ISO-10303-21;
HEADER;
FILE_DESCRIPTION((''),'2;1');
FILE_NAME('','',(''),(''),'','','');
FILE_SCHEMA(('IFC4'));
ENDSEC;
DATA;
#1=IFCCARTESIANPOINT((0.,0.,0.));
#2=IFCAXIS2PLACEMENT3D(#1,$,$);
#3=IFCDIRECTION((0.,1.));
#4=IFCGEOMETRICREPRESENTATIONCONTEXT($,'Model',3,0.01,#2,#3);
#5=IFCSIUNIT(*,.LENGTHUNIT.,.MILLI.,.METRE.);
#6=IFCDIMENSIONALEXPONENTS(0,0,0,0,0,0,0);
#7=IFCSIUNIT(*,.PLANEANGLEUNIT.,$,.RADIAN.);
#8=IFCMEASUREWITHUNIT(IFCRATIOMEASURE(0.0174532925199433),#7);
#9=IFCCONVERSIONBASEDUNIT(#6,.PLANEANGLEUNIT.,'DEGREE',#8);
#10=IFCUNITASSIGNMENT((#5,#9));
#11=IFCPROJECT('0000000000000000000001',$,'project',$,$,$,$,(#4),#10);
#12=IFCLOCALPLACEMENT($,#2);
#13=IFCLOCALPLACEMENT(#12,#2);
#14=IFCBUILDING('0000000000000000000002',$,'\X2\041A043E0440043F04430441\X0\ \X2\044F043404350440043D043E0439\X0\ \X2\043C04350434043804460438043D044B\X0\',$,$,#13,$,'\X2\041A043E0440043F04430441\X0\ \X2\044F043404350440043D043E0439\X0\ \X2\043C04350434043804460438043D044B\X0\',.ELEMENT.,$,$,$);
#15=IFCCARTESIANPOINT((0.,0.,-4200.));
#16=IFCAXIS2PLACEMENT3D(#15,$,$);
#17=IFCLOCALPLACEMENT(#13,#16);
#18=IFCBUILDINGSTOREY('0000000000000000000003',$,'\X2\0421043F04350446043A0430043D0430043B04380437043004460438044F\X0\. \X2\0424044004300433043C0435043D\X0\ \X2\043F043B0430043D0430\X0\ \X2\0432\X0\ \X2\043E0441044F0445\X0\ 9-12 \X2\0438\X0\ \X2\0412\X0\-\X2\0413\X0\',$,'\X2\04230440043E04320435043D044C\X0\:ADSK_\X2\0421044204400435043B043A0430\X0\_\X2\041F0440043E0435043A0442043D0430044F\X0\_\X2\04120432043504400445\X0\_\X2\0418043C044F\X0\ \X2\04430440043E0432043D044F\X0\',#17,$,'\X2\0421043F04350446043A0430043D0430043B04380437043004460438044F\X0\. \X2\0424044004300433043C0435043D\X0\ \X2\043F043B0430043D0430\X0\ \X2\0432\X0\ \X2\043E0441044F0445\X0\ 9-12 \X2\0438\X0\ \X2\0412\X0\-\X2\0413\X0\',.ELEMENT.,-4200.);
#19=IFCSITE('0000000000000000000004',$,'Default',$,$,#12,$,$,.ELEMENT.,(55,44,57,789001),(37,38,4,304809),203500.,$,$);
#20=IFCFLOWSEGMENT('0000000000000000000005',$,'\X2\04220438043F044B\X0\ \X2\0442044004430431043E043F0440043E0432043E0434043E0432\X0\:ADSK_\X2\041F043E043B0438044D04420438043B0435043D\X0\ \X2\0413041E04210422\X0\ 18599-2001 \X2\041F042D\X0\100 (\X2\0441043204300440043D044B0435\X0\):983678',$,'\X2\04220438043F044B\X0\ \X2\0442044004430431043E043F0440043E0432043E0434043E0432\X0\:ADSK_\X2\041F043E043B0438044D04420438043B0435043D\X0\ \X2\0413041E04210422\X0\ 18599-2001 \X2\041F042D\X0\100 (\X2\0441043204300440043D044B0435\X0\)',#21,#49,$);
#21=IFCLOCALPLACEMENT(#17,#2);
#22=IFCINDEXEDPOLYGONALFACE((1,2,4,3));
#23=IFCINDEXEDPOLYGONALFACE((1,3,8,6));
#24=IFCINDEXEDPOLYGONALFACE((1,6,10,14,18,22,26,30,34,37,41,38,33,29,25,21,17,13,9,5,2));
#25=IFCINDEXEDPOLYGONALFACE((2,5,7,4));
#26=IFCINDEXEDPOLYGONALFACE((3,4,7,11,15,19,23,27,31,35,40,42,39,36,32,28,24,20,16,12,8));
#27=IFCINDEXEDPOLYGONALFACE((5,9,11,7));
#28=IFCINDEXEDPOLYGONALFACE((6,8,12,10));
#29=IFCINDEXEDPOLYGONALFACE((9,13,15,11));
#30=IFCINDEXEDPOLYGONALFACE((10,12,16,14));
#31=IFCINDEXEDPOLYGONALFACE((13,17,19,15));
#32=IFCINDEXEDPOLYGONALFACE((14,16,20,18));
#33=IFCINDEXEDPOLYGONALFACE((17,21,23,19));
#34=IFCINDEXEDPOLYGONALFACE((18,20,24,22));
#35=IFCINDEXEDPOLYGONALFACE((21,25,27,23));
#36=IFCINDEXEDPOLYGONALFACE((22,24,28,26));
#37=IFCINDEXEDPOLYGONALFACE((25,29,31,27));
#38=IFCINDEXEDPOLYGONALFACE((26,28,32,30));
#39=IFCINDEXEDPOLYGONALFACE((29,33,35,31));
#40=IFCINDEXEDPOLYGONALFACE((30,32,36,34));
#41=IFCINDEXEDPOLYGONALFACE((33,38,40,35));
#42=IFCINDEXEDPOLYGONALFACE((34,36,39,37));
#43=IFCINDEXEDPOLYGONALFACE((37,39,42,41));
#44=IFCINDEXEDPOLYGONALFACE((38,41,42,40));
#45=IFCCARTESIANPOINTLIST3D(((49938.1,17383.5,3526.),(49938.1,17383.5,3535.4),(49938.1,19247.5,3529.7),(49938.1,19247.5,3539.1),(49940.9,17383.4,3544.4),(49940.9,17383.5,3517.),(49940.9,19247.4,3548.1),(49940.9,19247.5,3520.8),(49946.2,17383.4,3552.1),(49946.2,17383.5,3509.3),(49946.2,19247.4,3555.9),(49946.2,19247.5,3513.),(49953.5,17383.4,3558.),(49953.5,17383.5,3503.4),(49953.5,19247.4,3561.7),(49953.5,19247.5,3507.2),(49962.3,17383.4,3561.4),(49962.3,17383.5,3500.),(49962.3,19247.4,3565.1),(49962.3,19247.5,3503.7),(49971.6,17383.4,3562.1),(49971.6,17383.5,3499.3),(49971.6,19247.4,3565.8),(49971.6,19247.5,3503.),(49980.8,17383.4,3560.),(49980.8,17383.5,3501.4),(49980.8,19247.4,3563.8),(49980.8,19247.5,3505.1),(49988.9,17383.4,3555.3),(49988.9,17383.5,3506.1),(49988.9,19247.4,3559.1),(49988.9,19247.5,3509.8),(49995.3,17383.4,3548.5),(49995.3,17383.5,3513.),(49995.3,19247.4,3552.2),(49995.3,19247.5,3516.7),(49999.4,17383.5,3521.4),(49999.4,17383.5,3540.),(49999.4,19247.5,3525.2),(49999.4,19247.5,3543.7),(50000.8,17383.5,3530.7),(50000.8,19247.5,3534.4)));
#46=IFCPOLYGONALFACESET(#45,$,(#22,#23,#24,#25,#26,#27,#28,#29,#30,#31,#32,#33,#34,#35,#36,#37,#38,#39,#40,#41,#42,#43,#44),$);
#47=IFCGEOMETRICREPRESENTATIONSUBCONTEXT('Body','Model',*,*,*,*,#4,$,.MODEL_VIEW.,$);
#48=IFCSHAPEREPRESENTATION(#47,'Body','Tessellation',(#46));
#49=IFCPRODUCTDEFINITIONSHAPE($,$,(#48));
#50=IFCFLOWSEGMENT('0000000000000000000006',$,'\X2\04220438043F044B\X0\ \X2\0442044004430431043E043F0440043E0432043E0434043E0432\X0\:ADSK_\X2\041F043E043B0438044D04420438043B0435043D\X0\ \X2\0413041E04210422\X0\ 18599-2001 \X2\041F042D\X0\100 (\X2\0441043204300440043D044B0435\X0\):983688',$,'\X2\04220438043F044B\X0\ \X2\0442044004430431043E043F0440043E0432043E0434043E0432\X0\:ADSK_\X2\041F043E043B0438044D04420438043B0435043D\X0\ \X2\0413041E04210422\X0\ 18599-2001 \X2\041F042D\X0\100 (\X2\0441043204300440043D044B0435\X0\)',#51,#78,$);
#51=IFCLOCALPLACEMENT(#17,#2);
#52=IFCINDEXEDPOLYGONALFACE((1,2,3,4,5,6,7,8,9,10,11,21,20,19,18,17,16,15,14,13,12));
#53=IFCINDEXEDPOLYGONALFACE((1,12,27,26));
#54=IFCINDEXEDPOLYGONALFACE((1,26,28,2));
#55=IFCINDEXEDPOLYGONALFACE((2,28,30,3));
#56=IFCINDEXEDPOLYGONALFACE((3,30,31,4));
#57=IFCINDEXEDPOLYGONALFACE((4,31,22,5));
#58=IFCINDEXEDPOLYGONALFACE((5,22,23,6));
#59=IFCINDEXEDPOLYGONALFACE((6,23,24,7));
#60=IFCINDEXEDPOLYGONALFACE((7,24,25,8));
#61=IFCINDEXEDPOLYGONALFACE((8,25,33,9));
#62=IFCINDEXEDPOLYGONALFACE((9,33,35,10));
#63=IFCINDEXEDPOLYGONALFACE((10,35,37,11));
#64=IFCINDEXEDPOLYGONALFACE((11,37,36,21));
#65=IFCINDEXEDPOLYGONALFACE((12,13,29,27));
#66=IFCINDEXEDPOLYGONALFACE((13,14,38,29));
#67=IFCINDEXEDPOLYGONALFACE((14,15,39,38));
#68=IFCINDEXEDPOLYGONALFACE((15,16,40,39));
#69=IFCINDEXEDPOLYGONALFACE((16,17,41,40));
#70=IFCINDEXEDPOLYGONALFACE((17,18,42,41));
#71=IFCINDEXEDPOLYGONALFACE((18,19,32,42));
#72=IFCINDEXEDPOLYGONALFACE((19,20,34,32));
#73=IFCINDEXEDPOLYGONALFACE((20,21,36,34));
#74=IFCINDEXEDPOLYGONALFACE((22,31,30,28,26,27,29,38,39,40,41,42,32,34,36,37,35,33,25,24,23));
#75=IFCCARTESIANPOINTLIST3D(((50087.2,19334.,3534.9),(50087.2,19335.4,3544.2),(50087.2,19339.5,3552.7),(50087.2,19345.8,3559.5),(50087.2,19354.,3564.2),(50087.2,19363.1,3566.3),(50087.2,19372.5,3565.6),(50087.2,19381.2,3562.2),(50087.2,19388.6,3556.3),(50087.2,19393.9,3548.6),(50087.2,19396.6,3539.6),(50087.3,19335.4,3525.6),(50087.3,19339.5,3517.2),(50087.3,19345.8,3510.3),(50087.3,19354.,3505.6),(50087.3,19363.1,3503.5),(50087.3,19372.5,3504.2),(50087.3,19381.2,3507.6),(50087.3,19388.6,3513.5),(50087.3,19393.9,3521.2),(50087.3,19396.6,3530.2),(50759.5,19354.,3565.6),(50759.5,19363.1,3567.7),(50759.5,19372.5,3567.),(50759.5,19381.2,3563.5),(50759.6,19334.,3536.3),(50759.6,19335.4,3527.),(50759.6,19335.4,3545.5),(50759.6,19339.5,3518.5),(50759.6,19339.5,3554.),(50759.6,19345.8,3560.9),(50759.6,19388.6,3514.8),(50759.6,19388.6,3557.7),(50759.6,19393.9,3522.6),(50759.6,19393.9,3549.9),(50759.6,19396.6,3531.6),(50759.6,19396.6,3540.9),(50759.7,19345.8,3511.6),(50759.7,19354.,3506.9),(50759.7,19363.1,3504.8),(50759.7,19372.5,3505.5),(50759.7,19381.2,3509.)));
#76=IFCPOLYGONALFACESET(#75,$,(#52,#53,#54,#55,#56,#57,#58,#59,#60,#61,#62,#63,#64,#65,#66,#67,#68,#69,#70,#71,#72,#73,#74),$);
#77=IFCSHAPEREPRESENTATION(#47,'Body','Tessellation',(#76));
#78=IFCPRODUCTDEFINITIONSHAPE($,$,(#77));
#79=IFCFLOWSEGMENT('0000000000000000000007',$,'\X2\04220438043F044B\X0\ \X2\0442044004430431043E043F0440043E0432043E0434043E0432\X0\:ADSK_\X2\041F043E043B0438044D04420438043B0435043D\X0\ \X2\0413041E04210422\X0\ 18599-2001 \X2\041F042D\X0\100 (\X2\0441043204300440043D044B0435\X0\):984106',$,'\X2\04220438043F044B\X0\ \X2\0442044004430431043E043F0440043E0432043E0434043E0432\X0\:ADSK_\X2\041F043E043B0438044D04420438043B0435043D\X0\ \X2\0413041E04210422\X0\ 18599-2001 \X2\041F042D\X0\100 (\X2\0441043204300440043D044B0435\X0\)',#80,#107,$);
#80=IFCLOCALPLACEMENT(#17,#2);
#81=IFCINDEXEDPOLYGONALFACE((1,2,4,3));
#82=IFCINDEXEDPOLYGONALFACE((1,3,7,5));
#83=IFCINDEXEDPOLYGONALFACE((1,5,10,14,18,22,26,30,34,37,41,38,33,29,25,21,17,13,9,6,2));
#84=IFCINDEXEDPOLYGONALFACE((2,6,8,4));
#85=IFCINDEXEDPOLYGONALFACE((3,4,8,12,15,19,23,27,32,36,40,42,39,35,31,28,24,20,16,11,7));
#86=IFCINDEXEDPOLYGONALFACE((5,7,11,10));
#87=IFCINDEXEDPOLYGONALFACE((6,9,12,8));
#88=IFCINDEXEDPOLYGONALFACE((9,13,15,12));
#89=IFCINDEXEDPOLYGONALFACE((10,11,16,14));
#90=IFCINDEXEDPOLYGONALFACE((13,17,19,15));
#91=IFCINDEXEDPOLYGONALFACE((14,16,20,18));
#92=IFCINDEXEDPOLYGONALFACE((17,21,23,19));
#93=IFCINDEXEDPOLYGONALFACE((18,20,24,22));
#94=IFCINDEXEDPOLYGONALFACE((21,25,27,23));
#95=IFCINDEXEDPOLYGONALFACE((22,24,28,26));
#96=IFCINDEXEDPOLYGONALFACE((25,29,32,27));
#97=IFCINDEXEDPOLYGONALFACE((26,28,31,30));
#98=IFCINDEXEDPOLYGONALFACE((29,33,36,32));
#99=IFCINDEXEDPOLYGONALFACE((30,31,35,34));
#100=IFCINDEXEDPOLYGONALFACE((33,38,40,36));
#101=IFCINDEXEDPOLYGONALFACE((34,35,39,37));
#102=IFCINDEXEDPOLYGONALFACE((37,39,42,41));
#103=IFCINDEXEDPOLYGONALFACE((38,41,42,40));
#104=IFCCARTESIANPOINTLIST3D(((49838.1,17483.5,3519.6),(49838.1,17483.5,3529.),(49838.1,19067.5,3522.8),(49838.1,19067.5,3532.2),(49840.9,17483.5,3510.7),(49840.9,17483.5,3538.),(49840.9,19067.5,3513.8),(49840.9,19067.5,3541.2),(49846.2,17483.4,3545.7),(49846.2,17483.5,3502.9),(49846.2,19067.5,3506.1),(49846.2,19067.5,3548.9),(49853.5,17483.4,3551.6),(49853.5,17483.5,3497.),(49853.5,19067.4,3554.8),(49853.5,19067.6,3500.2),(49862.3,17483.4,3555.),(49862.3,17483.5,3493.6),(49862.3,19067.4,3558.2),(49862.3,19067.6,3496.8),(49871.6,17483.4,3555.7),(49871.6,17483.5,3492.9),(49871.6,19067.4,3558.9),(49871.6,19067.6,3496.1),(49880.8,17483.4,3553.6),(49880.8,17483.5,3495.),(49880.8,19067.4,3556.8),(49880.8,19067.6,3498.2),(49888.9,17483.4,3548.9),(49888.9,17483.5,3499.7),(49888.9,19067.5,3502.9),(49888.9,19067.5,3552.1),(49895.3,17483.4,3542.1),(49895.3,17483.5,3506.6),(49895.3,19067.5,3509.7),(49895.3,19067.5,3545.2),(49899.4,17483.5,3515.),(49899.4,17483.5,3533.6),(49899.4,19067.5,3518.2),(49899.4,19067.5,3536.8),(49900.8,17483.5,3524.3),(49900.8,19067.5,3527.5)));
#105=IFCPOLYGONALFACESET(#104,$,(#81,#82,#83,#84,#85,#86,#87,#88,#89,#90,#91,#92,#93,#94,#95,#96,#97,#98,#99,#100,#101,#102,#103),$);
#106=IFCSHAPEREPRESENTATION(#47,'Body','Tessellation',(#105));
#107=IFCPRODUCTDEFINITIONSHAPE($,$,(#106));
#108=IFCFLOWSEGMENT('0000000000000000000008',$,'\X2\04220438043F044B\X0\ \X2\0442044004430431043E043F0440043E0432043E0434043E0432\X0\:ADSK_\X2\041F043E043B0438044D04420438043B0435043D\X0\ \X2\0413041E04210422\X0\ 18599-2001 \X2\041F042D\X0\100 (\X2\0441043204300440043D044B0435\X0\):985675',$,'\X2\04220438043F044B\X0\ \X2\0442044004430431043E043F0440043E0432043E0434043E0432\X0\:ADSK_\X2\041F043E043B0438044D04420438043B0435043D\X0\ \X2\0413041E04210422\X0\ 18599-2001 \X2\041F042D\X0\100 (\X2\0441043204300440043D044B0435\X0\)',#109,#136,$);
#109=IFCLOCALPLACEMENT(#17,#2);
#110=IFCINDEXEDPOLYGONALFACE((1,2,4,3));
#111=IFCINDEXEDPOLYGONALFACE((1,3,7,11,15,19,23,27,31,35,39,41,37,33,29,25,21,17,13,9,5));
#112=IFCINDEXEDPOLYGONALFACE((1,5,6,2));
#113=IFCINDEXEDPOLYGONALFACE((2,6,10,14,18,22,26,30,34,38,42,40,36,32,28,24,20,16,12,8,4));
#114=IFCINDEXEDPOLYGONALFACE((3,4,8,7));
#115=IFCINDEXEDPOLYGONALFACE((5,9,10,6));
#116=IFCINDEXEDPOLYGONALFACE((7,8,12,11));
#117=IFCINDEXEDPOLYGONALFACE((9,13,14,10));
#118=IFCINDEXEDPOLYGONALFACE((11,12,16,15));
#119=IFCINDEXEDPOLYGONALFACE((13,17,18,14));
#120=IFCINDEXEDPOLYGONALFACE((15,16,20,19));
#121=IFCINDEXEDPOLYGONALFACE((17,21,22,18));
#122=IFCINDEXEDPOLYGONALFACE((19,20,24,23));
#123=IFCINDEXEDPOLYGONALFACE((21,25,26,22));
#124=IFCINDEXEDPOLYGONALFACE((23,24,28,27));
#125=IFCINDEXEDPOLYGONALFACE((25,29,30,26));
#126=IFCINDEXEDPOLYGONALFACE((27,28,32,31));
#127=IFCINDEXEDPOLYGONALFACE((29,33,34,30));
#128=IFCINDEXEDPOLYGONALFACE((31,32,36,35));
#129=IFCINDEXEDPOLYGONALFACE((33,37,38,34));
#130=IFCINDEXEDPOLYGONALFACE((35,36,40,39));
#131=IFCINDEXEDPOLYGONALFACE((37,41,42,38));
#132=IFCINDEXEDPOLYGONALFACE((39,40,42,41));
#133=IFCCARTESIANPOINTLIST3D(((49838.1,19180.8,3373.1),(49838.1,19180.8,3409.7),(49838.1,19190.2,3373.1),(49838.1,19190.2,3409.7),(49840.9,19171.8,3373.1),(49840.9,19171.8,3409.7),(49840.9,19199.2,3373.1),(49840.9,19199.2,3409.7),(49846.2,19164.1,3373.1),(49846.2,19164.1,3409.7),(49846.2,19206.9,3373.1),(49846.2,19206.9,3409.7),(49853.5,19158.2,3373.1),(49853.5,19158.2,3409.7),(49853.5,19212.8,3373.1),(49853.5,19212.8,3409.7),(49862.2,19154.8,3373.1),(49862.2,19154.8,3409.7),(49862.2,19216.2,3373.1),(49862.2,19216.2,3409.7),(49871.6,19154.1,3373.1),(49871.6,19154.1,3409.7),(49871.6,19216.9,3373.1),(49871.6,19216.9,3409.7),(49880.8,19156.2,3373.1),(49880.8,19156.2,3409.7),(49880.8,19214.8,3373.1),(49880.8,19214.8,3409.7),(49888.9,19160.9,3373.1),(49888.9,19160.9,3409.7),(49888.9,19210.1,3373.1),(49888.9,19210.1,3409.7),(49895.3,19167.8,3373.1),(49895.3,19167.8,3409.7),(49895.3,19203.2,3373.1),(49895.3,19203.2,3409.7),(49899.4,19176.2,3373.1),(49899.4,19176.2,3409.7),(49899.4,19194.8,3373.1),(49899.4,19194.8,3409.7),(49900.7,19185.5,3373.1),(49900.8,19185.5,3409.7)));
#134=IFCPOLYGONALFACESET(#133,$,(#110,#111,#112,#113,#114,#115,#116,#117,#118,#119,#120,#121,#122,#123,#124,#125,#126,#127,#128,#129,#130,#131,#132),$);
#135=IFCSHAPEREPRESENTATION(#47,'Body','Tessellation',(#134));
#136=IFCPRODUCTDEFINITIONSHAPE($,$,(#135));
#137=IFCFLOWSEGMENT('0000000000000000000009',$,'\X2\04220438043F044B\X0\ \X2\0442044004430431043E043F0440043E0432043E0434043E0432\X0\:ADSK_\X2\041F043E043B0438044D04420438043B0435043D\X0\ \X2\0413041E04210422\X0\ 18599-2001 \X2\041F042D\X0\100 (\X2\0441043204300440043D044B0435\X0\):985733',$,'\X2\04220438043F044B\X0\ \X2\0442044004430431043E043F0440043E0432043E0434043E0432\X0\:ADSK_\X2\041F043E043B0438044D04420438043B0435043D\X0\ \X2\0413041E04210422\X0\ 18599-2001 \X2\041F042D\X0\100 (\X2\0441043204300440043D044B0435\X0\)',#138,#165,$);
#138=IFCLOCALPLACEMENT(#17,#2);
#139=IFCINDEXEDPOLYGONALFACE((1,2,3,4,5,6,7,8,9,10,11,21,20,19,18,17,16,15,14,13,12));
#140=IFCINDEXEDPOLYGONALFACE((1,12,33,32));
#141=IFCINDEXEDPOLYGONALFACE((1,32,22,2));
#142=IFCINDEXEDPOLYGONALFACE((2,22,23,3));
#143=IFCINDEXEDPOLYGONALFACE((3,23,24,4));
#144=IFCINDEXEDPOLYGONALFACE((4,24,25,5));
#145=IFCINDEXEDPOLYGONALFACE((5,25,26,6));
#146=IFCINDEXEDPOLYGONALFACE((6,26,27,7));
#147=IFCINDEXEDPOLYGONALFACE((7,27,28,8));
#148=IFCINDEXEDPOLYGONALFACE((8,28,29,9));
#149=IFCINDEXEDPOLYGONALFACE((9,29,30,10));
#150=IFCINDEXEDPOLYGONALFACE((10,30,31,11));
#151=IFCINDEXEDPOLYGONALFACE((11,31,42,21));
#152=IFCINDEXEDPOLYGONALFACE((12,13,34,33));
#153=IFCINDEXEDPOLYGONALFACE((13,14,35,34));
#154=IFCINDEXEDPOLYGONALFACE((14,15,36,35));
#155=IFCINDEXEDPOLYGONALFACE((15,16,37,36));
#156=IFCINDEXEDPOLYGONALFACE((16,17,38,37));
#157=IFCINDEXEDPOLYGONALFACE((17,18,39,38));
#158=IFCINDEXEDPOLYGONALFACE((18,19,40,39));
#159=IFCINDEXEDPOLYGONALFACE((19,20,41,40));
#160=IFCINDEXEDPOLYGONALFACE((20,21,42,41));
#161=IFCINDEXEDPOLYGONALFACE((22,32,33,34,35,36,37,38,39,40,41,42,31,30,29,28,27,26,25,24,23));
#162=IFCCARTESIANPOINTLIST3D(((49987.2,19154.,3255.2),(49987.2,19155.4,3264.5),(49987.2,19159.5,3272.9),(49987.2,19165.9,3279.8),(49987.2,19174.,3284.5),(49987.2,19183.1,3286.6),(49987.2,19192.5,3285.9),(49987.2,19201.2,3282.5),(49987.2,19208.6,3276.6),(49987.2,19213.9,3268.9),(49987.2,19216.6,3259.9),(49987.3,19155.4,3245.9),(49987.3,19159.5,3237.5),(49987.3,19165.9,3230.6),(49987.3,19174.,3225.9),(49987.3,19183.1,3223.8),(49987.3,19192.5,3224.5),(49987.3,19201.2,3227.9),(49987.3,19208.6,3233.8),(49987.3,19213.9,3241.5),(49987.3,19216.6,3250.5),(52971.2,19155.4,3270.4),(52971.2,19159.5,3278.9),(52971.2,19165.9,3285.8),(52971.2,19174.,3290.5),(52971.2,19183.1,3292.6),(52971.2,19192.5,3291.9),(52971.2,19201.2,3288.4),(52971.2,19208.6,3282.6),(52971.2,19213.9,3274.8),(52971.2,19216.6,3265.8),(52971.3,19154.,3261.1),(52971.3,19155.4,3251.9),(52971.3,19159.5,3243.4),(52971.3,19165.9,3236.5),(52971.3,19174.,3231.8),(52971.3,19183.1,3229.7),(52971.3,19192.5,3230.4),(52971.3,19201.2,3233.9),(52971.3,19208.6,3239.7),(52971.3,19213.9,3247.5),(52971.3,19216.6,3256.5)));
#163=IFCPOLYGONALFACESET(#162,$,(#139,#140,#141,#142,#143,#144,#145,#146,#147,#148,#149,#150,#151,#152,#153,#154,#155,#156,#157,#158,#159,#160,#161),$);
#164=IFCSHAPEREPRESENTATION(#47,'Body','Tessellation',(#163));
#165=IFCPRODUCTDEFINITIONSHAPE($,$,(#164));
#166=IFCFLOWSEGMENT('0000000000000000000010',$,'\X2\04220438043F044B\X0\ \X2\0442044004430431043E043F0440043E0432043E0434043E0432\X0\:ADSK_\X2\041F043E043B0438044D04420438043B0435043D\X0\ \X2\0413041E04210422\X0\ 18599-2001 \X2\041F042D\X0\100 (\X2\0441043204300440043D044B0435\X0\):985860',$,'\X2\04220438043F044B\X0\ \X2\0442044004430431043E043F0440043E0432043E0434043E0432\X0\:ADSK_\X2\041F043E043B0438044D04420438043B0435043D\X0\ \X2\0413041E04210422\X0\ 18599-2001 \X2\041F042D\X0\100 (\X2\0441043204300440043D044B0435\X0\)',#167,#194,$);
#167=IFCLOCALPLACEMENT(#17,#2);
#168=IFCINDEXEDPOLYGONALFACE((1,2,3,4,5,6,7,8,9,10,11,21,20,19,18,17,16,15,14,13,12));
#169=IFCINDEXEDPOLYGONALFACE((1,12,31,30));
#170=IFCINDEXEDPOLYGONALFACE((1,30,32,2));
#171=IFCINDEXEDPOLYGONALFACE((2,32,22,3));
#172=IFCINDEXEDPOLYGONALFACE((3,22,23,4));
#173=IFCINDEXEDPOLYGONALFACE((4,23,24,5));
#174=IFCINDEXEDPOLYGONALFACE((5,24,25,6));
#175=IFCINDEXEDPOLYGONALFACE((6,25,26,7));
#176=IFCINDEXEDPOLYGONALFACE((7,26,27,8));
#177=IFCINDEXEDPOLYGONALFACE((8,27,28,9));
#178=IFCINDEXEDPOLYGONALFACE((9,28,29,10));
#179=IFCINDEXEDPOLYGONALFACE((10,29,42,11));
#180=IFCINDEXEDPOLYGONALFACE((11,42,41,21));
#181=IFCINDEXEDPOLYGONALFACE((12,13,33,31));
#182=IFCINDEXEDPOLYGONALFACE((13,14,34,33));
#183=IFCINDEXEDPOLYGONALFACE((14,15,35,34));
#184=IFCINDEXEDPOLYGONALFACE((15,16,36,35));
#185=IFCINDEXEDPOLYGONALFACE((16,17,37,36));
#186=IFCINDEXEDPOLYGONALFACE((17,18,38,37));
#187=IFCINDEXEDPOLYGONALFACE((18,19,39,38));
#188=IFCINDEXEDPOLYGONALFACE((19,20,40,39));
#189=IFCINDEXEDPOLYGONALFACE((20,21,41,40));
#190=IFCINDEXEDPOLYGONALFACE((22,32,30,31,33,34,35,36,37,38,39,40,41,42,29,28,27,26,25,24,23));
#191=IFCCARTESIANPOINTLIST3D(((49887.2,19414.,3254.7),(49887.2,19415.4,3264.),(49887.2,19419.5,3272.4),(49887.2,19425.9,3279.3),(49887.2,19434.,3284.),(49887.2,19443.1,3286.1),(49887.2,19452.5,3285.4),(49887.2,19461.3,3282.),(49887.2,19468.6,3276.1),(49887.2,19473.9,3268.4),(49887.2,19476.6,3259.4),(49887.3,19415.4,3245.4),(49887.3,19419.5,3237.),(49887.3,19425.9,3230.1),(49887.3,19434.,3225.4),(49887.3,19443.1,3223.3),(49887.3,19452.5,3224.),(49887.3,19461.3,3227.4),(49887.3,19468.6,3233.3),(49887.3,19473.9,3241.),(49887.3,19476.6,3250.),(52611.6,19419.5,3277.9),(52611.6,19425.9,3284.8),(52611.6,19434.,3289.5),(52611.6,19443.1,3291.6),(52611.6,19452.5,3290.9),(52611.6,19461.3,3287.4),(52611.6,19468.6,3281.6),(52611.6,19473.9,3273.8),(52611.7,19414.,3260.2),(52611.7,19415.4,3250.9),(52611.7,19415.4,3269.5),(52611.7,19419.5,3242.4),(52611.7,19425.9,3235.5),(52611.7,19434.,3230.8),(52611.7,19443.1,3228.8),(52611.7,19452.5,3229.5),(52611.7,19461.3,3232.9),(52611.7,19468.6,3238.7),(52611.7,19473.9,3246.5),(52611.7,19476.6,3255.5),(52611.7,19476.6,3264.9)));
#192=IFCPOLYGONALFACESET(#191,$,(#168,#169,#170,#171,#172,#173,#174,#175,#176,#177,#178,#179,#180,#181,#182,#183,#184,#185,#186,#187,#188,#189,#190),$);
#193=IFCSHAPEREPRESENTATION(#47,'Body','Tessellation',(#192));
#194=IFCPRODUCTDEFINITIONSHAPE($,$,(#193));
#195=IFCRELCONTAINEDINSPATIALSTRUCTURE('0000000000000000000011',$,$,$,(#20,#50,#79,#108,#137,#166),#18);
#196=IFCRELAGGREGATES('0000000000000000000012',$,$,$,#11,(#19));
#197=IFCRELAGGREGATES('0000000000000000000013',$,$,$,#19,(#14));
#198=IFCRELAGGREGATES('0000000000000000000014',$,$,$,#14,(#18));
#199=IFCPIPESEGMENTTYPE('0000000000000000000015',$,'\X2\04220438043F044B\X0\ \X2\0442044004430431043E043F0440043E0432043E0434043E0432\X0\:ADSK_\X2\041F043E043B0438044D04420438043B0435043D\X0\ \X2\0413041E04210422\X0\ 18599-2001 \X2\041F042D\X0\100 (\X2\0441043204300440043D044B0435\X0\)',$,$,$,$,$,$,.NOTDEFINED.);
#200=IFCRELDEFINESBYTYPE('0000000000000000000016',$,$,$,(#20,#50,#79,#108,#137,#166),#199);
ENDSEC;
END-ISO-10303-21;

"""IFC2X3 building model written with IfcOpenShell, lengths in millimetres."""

from ifc_helpers import new_model, entity, si_unit, converted_unit, direction, frame, origin, origin_2d_with_axis, place, context, subcontext, project, spatial, circle, extrude, type_object, element, save


model = new_model("IFC2X3")

# Units and contexts
model_context = context("Model", 3, precision=0.01, world=origin(), true_north=direction((0.0, 1.0)))
body_context = subcontext(model_context, "Body", "Model", "MODEL_VIEW")
ifc_project = project(units=[si_unit("LENGTHUNIT", "METRE", prefix="MILLI"), converted_unit("PLANEANGLEUNIT", "DEGREE", entity("IfcRatioMeasure", 0.0174532925199433), si_unit("PLANEANGLEUNIT", "RADIAN"), dimensions=[0, 0, 0, 0, 0, 0, 0])], contexts=[model_context])

# Site, building, storey
site_placement = place(None, origin())
site = spatial("IfcSite", under=ifc_project, at=site_placement, Name="Default", CompositionType="ELEMENT", RefLatitude=(55, 44, 57, 789001), RefLongitude=(37, 38, 4, 304809), RefElevation=203500.0)
building_placement = place(site_placement, origin())
building = spatial("IfcBuilding", under=site, at=building_placement, Name="Корпус ядерной медицины", LongName="Корпус ядерной медицины", CompositionType="ELEMENT")
storey_placement = place(building_placement, frame((0.0, 0.0, -4200.0)))
storey = spatial("IfcBuildingStorey", under=building, at=storey_placement, Name="Спецканализация. Фрагмен плана в осях 9-12 и В-Г", ObjectType="Уровень:ADSK_Стрелка_Проектная_Вверх_Имя уровня", LongName="Спецканализация. Фрагмен плана в осях 9-12 и В-Г", CompositionType="ELEMENT", Elevation=-4200.0)

# Flow segments
pipe_segment_type = type_object("IfcPipeSegmentType", Name="Типы трубопроводов:ADSK_Полиэтилен ГОСТ 18599-2001 ПЭ100 (сварные)", PredefinedType="NOTDEFINED")
flow_segment_1_placement = place(storey_placement, frame((49936.2, 17383.4, 3497.6)))
element("IfcFlowSegment", 1, at=flow_segment_1_placement, inside=storey, type_object=pipe_segment_type, Name="Типы трубопроводов:ADSK_Полиэтилен ГОСТ 18599-2001 ПЭ100 (сварные):983678", ObjectType="Типы трубопроводов:ADSK_Полиэтилен ГОСТ 18599-2001 ПЭ100 (сварные)", context=body_context, shape_type="SweptSolid", body=[
    extrude(circle(Radius=31.5, at=origin_2d_with_axis()), frame((33.1, 0.1, 33.1), z_axis=(0.0, 0.999998, 0.002), x_axis=(1.0, 0.0, 0.0)), (0.0, 0.0, 1.0), 1864.0),
])
flow_segment_2_placement = place(storey_placement, frame((50087.2, 19332.4, 3501.8)))
element("IfcFlowSegment", 2, at=flow_segment_2_placement, inside=storey, type_object=pipe_segment_type, Name="Типы трубопроводов:ADSK_Полиэтилен ГОСТ 18599-2001 ПЭ100 (сварные):983688", ObjectType="Типы трубопроводов:ADSK_Полиэтилен ГОСТ 18599-2001 ПЭ100 (сварные)", context=body_context, shape_type="SweptSolid", body=[
    extrude(circle(Radius=31.5, at=origin_2d_with_axis()), frame((0.1, 33.1, 33.1), z_axis=(0.999998, 0.0, 0.002), x_axis=(0.0, -1.0, 0.0)), (0.0, 0.0, 1.0), 672.4),
])
flow_segment_3_placement = place(storey_placement, frame((49836.2, 17483.4, 3491.2)))
element("IfcFlowSegment", 3, at=flow_segment_3_placement, inside=storey, type_object=pipe_segment_type, Name="Типы трубопроводов:ADSK_Полиэтилен ГОСТ 18599-2001 ПЭ100 (сварные):984106", ObjectType="Типы трубопроводов:ADSK_Полиэтилен ГОСТ 18599-2001 ПЭ100 (сварные)", context=body_context, shape_type="SweptSolid", body=[
    extrude(circle(Radius=31.5, at=origin_2d_with_axis()), frame((33.1, 0.1, 33.1), z_axis=(0.0, 0.999998, 0.002), x_axis=(1.0, 0.0, 0.0)), (0.0, 0.0, 1.0), 1584.0),
])
flow_segment_4_placement = place(storey_placement, frame((49836.2, 19152.4, 3373.1)))
element("IfcFlowSegment", 4, at=flow_segment_4_placement, inside=storey, type_object=pipe_segment_type, Name="Типы трубопроводов:ADSK_Полиэтилен ГОСТ 18599-2001 ПЭ100 (сварные):985675", ObjectType="Типы трубопроводов:ADSK_Полиэтилен ГОСТ 18599-2001 ПЭ100 (сварные)", context=body_context, shape_type="SweptSolid", body=[
    extrude(circle(Radius=31.5, at=origin_2d_with_axis()), frame((33.1, 33.1, 0.0), z_axis=(0.000128, -0.000026, 1.0), x_axis=(1.0, 0.0, -0.000128)), (0.0, 0.0, 1.0), 36.6),
])
flow_segment_5_placement = place(storey_placement, frame((49987.2, 19152.4, 3222.1)))
element("IfcFlowSegment", 5, at=flow_segment_5_placement, inside=storey, type_object=pipe_segment_type, Name="Типы трубопроводов:ADSK_Полиэтилен ГОСТ 18599-2001 ПЭ100 (сварные):985733", ObjectType="Типы трубопроводов:ADSK_Полиэтилен ГОСТ 18599-2001 ПЭ100 (сварные)", context=body_context, shape_type="SweptSolid", body=[
    extrude(circle(Radius=31.5, at=origin_2d_with_axis()), frame((0.1, 33.1, 33.1), z_axis=(0.999998, 0.0, 0.001993), x_axis=(0.0, -1.0, 0.0)), (0.0, 0.0, 1.0), 2984.0),
])
flow_segment_6_placement = place(storey_placement, frame((49887.2, 19412.4, 3221.6)))
element("IfcFlowSegment", 6, at=flow_segment_6_placement, inside=storey, type_object=pipe_segment_type, Name="Типы трубопроводов:ADSK_Полиэтилен ГОСТ 18599-2001 ПЭ100 (сварные):985860", ObjectType="Типы трубопроводов:ADSK_Полиэтилен ГОСТ 18599-2001 ПЭ100 (сварные)", context=body_context, shape_type="SweptSolid", body=[
    extrude(circle(Radius=31.5, at=origin_2d_with_axis()), frame((0.1, 33.1, 33.1), z_axis=(0.999998, 0.0, 0.002007), x_axis=(0.0, -1.0, 0.0)), (0.0, 0.0, 1.0), 2724.4),
])

save(model, "model.ifc")
